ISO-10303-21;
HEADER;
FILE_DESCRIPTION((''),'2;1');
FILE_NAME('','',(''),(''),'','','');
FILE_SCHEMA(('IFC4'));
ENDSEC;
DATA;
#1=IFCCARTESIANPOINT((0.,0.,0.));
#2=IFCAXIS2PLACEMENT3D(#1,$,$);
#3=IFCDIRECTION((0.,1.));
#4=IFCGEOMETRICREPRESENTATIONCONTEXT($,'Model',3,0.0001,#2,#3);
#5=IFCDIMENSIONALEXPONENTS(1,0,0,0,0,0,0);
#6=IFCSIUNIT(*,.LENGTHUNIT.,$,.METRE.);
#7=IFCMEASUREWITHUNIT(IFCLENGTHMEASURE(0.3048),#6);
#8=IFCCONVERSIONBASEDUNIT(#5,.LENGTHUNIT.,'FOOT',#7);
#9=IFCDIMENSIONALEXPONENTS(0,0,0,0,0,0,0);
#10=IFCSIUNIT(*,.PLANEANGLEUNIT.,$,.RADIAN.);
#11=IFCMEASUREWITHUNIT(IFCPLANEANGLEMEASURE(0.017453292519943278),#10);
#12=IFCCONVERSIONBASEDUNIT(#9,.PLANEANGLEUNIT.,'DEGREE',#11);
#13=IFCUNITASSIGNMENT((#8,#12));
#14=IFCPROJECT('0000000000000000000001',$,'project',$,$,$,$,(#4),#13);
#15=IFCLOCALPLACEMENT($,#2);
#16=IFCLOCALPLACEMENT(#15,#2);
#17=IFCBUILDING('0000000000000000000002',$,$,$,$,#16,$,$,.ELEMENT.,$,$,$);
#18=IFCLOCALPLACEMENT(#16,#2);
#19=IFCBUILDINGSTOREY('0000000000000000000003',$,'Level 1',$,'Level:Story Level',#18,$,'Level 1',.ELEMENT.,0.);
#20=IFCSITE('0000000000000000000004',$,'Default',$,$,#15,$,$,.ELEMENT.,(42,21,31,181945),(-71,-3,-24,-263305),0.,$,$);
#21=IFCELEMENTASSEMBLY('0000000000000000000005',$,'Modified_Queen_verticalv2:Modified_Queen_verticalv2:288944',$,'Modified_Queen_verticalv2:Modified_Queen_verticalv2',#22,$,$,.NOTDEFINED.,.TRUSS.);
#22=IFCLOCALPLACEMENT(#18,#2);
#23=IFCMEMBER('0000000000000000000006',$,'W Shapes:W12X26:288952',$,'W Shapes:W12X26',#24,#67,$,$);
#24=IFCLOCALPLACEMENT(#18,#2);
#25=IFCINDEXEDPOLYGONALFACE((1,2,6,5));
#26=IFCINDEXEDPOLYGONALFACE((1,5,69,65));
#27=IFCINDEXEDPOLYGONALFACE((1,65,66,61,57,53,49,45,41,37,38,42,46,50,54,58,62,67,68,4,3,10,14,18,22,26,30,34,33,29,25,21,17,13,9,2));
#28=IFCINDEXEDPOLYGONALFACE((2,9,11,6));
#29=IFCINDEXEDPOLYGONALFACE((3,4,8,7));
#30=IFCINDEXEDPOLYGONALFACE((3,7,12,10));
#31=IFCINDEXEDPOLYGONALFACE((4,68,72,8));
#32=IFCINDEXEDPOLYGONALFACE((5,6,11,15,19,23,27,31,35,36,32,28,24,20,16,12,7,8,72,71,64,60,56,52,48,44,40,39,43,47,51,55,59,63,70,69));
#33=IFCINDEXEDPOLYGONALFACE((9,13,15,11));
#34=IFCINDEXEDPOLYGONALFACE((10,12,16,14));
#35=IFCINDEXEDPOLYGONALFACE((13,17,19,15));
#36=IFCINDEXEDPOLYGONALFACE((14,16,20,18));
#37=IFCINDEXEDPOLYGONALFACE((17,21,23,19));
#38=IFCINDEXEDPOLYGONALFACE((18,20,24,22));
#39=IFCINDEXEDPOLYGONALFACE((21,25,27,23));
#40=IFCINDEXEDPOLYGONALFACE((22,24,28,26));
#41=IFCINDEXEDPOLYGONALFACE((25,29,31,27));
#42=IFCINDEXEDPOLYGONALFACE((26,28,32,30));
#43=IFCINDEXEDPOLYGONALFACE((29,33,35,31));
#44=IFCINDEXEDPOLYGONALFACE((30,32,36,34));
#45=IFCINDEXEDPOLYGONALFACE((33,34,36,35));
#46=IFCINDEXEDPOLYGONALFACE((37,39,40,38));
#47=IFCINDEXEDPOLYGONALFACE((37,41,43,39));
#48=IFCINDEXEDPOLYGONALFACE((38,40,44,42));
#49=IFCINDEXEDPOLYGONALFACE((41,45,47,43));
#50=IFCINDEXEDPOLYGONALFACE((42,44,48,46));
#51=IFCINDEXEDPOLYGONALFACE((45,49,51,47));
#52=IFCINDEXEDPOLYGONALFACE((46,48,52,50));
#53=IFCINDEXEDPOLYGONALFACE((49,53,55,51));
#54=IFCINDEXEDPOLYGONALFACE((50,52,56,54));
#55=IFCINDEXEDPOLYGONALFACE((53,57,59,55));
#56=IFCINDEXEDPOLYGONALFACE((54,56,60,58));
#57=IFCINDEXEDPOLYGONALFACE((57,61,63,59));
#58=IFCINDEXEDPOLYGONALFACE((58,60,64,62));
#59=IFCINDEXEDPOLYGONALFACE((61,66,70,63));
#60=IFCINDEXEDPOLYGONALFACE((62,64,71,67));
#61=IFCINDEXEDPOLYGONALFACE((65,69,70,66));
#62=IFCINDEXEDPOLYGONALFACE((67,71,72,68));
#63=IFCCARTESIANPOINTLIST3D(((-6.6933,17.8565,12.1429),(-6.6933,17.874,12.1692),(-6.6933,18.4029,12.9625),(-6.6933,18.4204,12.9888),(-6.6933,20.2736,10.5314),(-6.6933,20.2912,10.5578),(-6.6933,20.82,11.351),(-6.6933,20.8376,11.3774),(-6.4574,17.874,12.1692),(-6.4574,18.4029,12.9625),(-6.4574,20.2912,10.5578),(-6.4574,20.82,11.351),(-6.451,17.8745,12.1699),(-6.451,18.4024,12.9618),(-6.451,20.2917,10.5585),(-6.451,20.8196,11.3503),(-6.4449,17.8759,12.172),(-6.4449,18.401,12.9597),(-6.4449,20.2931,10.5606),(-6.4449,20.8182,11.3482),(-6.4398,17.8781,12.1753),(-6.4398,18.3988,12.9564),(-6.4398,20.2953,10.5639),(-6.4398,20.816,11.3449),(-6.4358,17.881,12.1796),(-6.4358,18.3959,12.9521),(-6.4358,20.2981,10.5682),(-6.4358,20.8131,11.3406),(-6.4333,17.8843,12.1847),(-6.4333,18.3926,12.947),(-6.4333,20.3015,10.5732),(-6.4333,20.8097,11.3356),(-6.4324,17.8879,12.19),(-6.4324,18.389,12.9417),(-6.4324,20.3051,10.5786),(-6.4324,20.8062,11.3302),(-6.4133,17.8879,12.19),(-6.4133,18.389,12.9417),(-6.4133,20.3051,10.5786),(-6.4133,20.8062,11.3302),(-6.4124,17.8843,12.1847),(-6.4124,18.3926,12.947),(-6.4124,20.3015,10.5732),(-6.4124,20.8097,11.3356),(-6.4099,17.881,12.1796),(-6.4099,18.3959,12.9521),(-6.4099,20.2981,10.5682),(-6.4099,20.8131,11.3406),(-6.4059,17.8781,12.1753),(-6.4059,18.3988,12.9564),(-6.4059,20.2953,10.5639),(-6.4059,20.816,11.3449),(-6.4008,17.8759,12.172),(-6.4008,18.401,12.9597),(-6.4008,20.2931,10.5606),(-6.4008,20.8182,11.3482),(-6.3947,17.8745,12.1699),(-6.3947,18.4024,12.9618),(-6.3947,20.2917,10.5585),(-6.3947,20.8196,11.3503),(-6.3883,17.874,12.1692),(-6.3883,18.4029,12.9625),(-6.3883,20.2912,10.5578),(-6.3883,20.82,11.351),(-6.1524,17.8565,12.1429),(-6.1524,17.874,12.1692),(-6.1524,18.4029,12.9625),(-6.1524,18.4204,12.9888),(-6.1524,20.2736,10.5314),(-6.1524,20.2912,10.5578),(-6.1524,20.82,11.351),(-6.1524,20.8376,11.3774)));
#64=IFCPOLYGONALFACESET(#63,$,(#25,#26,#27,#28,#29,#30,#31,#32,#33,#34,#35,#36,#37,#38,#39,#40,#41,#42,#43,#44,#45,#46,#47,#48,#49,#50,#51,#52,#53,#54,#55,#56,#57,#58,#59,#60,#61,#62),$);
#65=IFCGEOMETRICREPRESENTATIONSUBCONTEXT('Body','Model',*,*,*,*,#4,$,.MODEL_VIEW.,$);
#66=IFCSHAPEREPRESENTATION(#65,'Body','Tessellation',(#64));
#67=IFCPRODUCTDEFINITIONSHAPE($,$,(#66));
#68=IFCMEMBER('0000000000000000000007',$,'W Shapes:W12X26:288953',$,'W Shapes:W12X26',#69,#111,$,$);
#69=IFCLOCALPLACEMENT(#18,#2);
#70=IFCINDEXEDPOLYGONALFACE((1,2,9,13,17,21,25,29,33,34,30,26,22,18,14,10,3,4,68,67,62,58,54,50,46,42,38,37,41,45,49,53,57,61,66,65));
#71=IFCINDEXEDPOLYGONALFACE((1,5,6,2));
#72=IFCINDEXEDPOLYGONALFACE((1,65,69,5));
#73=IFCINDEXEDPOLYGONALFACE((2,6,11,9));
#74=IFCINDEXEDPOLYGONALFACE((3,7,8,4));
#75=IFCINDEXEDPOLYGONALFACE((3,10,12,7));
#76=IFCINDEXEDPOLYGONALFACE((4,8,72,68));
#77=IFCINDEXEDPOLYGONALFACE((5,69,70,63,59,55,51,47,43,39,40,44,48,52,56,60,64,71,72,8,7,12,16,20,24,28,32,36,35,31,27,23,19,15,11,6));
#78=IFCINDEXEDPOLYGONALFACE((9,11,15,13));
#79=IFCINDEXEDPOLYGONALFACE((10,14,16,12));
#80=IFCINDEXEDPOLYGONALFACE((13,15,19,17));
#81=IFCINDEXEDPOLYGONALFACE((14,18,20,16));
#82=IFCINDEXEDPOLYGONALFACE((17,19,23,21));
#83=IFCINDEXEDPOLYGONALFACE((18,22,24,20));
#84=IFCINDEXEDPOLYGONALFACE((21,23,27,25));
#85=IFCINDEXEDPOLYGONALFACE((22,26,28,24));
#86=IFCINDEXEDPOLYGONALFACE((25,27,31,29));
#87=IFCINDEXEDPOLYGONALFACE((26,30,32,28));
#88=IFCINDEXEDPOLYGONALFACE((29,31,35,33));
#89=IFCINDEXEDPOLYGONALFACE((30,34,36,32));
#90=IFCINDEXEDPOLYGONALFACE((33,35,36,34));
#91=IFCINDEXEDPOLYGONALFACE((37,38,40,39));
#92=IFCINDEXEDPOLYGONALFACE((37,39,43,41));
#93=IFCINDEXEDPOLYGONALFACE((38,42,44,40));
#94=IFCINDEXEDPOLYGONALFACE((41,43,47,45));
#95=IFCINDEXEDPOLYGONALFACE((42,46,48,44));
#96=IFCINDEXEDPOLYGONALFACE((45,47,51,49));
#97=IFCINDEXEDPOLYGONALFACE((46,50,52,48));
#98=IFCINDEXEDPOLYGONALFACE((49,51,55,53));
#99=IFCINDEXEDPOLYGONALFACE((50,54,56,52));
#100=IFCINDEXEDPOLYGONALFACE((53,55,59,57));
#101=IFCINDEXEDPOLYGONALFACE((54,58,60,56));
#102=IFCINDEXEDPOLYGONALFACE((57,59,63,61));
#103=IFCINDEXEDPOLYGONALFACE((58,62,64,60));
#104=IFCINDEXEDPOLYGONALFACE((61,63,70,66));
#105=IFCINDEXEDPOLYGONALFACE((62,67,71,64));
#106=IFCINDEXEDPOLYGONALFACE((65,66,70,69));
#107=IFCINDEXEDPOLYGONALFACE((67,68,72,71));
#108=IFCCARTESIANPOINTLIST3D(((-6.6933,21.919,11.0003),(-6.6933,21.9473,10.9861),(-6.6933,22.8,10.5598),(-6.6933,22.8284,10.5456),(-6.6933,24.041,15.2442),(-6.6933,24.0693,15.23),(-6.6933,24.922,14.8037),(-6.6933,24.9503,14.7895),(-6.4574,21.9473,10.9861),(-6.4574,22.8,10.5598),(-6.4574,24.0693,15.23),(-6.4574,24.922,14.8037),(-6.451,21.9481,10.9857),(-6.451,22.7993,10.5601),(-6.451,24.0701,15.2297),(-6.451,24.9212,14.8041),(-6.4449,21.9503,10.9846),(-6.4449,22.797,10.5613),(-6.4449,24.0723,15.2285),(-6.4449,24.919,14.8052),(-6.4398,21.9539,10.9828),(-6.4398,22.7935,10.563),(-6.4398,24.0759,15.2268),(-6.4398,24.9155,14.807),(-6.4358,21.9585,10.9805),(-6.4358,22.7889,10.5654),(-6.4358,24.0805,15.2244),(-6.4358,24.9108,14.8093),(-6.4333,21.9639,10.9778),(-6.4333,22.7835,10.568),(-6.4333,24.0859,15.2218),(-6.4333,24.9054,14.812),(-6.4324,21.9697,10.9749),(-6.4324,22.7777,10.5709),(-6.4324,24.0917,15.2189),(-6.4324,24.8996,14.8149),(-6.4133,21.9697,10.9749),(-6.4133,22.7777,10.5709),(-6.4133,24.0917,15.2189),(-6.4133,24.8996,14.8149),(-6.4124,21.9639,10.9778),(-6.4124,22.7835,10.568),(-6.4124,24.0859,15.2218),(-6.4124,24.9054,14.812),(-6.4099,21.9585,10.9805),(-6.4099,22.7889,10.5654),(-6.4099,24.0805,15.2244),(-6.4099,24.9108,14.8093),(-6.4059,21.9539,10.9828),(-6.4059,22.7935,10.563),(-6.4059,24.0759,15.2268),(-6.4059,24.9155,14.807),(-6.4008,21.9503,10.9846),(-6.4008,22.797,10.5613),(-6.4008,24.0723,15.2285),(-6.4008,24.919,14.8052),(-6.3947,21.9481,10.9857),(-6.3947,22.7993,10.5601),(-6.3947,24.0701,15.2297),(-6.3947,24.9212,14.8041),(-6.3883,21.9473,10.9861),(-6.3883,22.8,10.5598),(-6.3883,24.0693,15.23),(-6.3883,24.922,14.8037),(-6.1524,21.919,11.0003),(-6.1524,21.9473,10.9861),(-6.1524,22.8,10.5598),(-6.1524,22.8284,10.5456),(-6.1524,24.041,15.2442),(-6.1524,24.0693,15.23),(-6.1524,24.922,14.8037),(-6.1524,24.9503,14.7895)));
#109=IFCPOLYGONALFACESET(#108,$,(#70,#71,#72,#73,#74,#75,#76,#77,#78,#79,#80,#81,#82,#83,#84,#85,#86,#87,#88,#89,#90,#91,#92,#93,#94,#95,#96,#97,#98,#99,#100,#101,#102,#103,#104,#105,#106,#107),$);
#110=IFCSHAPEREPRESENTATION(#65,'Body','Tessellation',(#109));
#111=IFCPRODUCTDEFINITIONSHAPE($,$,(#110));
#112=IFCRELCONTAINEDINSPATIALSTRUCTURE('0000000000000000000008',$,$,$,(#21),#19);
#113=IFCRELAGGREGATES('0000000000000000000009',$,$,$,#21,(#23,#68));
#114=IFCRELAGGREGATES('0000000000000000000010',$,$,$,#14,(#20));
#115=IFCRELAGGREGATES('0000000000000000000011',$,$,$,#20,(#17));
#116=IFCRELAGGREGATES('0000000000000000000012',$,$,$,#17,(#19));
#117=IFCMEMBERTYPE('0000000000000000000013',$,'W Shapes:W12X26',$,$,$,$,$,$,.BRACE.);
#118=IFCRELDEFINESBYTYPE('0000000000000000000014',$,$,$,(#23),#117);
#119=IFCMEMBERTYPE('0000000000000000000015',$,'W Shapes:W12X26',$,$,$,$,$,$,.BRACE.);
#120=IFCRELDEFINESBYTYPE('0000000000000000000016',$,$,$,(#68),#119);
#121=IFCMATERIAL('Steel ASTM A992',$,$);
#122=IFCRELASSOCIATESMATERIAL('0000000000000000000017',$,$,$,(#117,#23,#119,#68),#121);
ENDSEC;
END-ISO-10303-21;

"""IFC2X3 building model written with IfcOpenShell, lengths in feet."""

from ifc_helpers import new_model, entity, si_unit, converted_unit, direction, frame, frame_2d, origin, place, context, subcontext, project, spatial, polyline, circle_curve, parameter, trimmed, segment, composite_curve, outline, extrude, source, transform, mapped, material, type_object, type_shapes, element, aggregate, save


model = new_model("IFC2X3")

# Units and contexts
model_context = context("Model", 3, precision=0.0001, world=origin(), true_north=direction((0.0, 1.0)))
body_context = subcontext(model_context, "Body", "Model", "MODEL_VIEW")
ifc_project = project(units=[converted_unit("LENGTHUNIT", "FOOT", entity("IfcLengthMeasure", 0.3048), si_unit("LENGTHUNIT", "METRE"), dimensions=[1, 0, 0, 0, 0, 0, 0]), converted_unit("PLANEANGLEUNIT", "DEGREE", entity("IfcPlaneAngleMeasure", 0.017453292519943278), si_unit("PLANEANGLEUNIT", "RADIAN"), dimensions=[0, 0, 0, 0, 0, 0, 0])], contexts=[model_context])

# Site, building, storey
site_placement = place(None, origin())
site = spatial("IfcSite", under=ifc_project, at=site_placement, Name="Default", CompositionType="ELEMENT", RefLatitude=(42, 21, 31, 181945), RefLongitude=(-71, -3, -24, -263305), RefElevation=0.0)
building_placement = place(site_placement, origin())
building = spatial("IfcBuilding", under=site, at=building_placement, CompositionType="ELEMENT")
storey_placement = place(building_placement, origin())
storey = spatial("IfcBuildingStorey", under=building, at=storey_placement, Name="Level 1", ObjectType="Level:Story Level", LongName="Level 1", CompositionType="ELEMENT", Elevation=0.0)

# Element assembly, members
assembly_placement = place(storey_placement, origin())
assembly = element("IfcElementAssembly", 1, at=assembly_placement, inside=storey, Name="Modified_Queen_verticalv2:Modified_Queen_verticalv2:288944", ObjectType="Modified_Queen_verticalv2:Modified_Queen_verticalv2", AssemblyPlace="NOTDEFINED", PredefinedType="TRUSS")
ifc_material = material(Name="Steel ASTM A992")
member_type_1 = type_object("IfcMemberType", Name="W Shapes:W12X26", PredefinedType="BRACE", material=ifc_material)
shared_shape_1 = source(origin(), body_context, "Body", "SweptSolid", [
    extrude(outline(composite_curve([segment(polyline([(-0.2704, -0.4767), (-0.2704, -0.5083)]), True, "CONTINUOUS"), segment(polyline([(-0.2704, -0.5083), (0.2704, -0.5083)]), True, "CONTINUOUS"), segment(polyline([(0.2704, -0.5083), (0.2704, -0.4767)]), True, "CONTINUOUS"), segment(polyline([(0.2704, -0.4767), (0.0346, -0.4767)]), True, "CONTINUOUS"), segment(trimmed(circle_curve(frame_2d((0.0346, -0.4517), x_axis=(0.0, -1.0)), 0.025), [parameter(270.0)], [parameter(360.0)], True, "PARAMETER"), False, "CONTINUOUS"), segment(polyline([(0.0096, -0.4517), (0.0096, 0.4517)]), True, "CONTINUOUS"), segment(trimmed(circle_curve(frame_2d((0.0346, 0.4517), x_axis=(-1.0, 0.0)), 0.025), [parameter(270.0)], [parameter(360.0)], True, "PARAMETER"), False, "CONTINUOUS"), segment(polyline([(0.0346, 0.4767), (0.2704, 0.4767)]), True, "CONTINUOUS"), segment(polyline([(0.2704, 0.4767), (0.2704, 0.5083)]), True, "CONTINUOUS"), segment(polyline([(0.2704, 0.5083), (-0.2704, 0.5083)]), True, "CONTINUOUS"), segment(polyline([(-0.2704, 0.5083), (-0.2704, 0.4767)]), True, "CONTINUOUS"), segment(polyline([(-0.2704, 0.4767), (-0.0346, 0.4767)]), True, "CONTINUOUS"), segment(trimmed(circle_curve(frame_2d((-0.0346, 0.4517), x_axis=(0.0, 1.0)), 0.025), [parameter(270.0)], [parameter(0.0)], True, "PARAMETER"), False, "CONTINUOUS"), segment(polyline([(-0.0096, 0.4517), (-0.0096, -0.4517)]), True, "CONTINUOUS"), segment(trimmed(circle_curve(frame_2d((-0.0346, -0.4517), x_axis=(1.0, 0.0)), 0.025), [parameter(270.0)], [parameter(0.0)], True, "PARAMETER"), False, "CONTINUOUS"), segment(polyline([(-0.0346, -0.4767), (-0.2704, -0.4767)]), True, "CONTINUOUS")], self_intersect=False)), frame((-1.8088, 0.0, 0.0), z_axis=(-1.0, 0.0, 0.0), x_axis=(0.0, -1.0, 0.0)), (0.0, 0.0, -1.0), 2.9051),
])
type_shapes(member_type_1, [shared_shape_1])
member_1_placement = place(assembly_placement, frame((-6.4228, 19.6435, 11.5625), z_axis=(0.0, -0.5547, -0.83205), x_axis=(0.0, 0.83205, -0.5547)))
member_1 = element("IfcMember", 2, at=member_1_placement, type_object=member_type_1, material=ifc_material, Name="W Shapes:W12X26:288952", ObjectType="W Shapes:W12X26", context=body_context, shape_type="MappedRepresentation", body=[
    mapped(shared_shape_1, transform((0.0, 0.0, 0.0), scale=1.0)),
])
member_type_2 = type_object("IfcMemberType", Name="W Shapes:W12X26", PredefinedType="BRACE", material=ifc_material)
shared_shape_2 = source(origin(), body_context, "Body", "SweptSolid", [
    extrude(outline(composite_curve([segment(polyline([(-0.2704, -0.4767), (-0.2704, -0.5083)]), True, "CONTINUOUS"), segment(polyline([(-0.2704, -0.5083), (0.2704, -0.5083)]), True, "CONTINUOUS"), segment(polyline([(0.2704, -0.5083), (0.2704, -0.4767)]), True, "CONTINUOUS"), segment(polyline([(0.2704, -0.4767), (0.0346, -0.4767)]), True, "CONTINUOUS"), segment(trimmed(circle_curve(frame_2d((0.0346, -0.4517), x_axis=(1.0, 0.0)), 0.025), [parameter(180.0)], [parameter(270.0)], True, "PARAMETER"), False, "CONTINUOUS"), segment(polyline([(0.0096, -0.4517), (0.0096, 0.4517)]), True, "CONTINUOUS"), segment(trimmed(circle_curve(frame_2d((0.0346, 0.4517), x_axis=(1.0, 0.0)), 0.025), [parameter(90.0)], [parameter(180.0)], True, "PARAMETER"), False, "CONTINUOUS"), segment(polyline([(0.0346, 0.4767), (0.2704, 0.4767)]), True, "CONTINUOUS"), segment(polyline([(0.2704, 0.4767), (0.2704, 0.5083)]), True, "CONTINUOUS"), segment(polyline([(0.2704, 0.5083), (-0.2704, 0.5083)]), True, "CONTINUOUS"), segment(polyline([(-0.2704, 0.5083), (-0.2704, 0.4767)]), True, "CONTINUOUS"), segment(polyline([(-0.2704, 0.4767), (-0.0346, 0.4767)]), True, "CONTINUOUS"), segment(trimmed(circle_curve(frame_2d((-0.0346, 0.4517), x_axis=(1.0, 0.0)), 0.025), [parameter(360.0)], [parameter(90.0)], True, "PARAMETER"), False, "CONTINUOUS"), segment(polyline([(-0.0096, 0.4517), (-0.0096, -0.4517)]), True, "CONTINUOUS"), segment(trimmed(circle_curve(frame_2d((-0.0346, -0.4517), x_axis=(1.0, 0.0)), 0.025), [parameter(270.0)], [parameter(360.0)], True, "PARAMETER"), False, "CONTINUOUS"), segment(polyline([(-0.0346, -0.4767), (-0.2704, -0.4767)]), True, "CONTINUOUS")], self_intersect=False)), frame((-2.6297, 0.0, 0.0), z_axis=(-1.0, 0.0, 0.0), x_axis=(0.0, -1.0, 0.0)), (0.0, 0.0, -1.0), 4.7449),
])
type_shapes(member_type_2, [shared_shape_2])
member_2_placement = place(assembly_placement, frame((-6.4228, 23.5497, 13.125), z_axis=(0.0, 0.894427, -0.447214), x_axis=(0.0, 0.447214, 0.894427)))
member_2 = element("IfcMember", 3, at=member_2_placement, type_object=member_type_2, material=ifc_material, Name="W Shapes:W12X26:288953", ObjectType="W Shapes:W12X26", context=body_context, shape_type="MappedRepresentation", body=[
    mapped(shared_shape_2, transform((0.0, 0.0, 0.0), scale=1.0)),
])
aggregate(assembly, [member_1, member_2])

save(model, "model.ifc")
